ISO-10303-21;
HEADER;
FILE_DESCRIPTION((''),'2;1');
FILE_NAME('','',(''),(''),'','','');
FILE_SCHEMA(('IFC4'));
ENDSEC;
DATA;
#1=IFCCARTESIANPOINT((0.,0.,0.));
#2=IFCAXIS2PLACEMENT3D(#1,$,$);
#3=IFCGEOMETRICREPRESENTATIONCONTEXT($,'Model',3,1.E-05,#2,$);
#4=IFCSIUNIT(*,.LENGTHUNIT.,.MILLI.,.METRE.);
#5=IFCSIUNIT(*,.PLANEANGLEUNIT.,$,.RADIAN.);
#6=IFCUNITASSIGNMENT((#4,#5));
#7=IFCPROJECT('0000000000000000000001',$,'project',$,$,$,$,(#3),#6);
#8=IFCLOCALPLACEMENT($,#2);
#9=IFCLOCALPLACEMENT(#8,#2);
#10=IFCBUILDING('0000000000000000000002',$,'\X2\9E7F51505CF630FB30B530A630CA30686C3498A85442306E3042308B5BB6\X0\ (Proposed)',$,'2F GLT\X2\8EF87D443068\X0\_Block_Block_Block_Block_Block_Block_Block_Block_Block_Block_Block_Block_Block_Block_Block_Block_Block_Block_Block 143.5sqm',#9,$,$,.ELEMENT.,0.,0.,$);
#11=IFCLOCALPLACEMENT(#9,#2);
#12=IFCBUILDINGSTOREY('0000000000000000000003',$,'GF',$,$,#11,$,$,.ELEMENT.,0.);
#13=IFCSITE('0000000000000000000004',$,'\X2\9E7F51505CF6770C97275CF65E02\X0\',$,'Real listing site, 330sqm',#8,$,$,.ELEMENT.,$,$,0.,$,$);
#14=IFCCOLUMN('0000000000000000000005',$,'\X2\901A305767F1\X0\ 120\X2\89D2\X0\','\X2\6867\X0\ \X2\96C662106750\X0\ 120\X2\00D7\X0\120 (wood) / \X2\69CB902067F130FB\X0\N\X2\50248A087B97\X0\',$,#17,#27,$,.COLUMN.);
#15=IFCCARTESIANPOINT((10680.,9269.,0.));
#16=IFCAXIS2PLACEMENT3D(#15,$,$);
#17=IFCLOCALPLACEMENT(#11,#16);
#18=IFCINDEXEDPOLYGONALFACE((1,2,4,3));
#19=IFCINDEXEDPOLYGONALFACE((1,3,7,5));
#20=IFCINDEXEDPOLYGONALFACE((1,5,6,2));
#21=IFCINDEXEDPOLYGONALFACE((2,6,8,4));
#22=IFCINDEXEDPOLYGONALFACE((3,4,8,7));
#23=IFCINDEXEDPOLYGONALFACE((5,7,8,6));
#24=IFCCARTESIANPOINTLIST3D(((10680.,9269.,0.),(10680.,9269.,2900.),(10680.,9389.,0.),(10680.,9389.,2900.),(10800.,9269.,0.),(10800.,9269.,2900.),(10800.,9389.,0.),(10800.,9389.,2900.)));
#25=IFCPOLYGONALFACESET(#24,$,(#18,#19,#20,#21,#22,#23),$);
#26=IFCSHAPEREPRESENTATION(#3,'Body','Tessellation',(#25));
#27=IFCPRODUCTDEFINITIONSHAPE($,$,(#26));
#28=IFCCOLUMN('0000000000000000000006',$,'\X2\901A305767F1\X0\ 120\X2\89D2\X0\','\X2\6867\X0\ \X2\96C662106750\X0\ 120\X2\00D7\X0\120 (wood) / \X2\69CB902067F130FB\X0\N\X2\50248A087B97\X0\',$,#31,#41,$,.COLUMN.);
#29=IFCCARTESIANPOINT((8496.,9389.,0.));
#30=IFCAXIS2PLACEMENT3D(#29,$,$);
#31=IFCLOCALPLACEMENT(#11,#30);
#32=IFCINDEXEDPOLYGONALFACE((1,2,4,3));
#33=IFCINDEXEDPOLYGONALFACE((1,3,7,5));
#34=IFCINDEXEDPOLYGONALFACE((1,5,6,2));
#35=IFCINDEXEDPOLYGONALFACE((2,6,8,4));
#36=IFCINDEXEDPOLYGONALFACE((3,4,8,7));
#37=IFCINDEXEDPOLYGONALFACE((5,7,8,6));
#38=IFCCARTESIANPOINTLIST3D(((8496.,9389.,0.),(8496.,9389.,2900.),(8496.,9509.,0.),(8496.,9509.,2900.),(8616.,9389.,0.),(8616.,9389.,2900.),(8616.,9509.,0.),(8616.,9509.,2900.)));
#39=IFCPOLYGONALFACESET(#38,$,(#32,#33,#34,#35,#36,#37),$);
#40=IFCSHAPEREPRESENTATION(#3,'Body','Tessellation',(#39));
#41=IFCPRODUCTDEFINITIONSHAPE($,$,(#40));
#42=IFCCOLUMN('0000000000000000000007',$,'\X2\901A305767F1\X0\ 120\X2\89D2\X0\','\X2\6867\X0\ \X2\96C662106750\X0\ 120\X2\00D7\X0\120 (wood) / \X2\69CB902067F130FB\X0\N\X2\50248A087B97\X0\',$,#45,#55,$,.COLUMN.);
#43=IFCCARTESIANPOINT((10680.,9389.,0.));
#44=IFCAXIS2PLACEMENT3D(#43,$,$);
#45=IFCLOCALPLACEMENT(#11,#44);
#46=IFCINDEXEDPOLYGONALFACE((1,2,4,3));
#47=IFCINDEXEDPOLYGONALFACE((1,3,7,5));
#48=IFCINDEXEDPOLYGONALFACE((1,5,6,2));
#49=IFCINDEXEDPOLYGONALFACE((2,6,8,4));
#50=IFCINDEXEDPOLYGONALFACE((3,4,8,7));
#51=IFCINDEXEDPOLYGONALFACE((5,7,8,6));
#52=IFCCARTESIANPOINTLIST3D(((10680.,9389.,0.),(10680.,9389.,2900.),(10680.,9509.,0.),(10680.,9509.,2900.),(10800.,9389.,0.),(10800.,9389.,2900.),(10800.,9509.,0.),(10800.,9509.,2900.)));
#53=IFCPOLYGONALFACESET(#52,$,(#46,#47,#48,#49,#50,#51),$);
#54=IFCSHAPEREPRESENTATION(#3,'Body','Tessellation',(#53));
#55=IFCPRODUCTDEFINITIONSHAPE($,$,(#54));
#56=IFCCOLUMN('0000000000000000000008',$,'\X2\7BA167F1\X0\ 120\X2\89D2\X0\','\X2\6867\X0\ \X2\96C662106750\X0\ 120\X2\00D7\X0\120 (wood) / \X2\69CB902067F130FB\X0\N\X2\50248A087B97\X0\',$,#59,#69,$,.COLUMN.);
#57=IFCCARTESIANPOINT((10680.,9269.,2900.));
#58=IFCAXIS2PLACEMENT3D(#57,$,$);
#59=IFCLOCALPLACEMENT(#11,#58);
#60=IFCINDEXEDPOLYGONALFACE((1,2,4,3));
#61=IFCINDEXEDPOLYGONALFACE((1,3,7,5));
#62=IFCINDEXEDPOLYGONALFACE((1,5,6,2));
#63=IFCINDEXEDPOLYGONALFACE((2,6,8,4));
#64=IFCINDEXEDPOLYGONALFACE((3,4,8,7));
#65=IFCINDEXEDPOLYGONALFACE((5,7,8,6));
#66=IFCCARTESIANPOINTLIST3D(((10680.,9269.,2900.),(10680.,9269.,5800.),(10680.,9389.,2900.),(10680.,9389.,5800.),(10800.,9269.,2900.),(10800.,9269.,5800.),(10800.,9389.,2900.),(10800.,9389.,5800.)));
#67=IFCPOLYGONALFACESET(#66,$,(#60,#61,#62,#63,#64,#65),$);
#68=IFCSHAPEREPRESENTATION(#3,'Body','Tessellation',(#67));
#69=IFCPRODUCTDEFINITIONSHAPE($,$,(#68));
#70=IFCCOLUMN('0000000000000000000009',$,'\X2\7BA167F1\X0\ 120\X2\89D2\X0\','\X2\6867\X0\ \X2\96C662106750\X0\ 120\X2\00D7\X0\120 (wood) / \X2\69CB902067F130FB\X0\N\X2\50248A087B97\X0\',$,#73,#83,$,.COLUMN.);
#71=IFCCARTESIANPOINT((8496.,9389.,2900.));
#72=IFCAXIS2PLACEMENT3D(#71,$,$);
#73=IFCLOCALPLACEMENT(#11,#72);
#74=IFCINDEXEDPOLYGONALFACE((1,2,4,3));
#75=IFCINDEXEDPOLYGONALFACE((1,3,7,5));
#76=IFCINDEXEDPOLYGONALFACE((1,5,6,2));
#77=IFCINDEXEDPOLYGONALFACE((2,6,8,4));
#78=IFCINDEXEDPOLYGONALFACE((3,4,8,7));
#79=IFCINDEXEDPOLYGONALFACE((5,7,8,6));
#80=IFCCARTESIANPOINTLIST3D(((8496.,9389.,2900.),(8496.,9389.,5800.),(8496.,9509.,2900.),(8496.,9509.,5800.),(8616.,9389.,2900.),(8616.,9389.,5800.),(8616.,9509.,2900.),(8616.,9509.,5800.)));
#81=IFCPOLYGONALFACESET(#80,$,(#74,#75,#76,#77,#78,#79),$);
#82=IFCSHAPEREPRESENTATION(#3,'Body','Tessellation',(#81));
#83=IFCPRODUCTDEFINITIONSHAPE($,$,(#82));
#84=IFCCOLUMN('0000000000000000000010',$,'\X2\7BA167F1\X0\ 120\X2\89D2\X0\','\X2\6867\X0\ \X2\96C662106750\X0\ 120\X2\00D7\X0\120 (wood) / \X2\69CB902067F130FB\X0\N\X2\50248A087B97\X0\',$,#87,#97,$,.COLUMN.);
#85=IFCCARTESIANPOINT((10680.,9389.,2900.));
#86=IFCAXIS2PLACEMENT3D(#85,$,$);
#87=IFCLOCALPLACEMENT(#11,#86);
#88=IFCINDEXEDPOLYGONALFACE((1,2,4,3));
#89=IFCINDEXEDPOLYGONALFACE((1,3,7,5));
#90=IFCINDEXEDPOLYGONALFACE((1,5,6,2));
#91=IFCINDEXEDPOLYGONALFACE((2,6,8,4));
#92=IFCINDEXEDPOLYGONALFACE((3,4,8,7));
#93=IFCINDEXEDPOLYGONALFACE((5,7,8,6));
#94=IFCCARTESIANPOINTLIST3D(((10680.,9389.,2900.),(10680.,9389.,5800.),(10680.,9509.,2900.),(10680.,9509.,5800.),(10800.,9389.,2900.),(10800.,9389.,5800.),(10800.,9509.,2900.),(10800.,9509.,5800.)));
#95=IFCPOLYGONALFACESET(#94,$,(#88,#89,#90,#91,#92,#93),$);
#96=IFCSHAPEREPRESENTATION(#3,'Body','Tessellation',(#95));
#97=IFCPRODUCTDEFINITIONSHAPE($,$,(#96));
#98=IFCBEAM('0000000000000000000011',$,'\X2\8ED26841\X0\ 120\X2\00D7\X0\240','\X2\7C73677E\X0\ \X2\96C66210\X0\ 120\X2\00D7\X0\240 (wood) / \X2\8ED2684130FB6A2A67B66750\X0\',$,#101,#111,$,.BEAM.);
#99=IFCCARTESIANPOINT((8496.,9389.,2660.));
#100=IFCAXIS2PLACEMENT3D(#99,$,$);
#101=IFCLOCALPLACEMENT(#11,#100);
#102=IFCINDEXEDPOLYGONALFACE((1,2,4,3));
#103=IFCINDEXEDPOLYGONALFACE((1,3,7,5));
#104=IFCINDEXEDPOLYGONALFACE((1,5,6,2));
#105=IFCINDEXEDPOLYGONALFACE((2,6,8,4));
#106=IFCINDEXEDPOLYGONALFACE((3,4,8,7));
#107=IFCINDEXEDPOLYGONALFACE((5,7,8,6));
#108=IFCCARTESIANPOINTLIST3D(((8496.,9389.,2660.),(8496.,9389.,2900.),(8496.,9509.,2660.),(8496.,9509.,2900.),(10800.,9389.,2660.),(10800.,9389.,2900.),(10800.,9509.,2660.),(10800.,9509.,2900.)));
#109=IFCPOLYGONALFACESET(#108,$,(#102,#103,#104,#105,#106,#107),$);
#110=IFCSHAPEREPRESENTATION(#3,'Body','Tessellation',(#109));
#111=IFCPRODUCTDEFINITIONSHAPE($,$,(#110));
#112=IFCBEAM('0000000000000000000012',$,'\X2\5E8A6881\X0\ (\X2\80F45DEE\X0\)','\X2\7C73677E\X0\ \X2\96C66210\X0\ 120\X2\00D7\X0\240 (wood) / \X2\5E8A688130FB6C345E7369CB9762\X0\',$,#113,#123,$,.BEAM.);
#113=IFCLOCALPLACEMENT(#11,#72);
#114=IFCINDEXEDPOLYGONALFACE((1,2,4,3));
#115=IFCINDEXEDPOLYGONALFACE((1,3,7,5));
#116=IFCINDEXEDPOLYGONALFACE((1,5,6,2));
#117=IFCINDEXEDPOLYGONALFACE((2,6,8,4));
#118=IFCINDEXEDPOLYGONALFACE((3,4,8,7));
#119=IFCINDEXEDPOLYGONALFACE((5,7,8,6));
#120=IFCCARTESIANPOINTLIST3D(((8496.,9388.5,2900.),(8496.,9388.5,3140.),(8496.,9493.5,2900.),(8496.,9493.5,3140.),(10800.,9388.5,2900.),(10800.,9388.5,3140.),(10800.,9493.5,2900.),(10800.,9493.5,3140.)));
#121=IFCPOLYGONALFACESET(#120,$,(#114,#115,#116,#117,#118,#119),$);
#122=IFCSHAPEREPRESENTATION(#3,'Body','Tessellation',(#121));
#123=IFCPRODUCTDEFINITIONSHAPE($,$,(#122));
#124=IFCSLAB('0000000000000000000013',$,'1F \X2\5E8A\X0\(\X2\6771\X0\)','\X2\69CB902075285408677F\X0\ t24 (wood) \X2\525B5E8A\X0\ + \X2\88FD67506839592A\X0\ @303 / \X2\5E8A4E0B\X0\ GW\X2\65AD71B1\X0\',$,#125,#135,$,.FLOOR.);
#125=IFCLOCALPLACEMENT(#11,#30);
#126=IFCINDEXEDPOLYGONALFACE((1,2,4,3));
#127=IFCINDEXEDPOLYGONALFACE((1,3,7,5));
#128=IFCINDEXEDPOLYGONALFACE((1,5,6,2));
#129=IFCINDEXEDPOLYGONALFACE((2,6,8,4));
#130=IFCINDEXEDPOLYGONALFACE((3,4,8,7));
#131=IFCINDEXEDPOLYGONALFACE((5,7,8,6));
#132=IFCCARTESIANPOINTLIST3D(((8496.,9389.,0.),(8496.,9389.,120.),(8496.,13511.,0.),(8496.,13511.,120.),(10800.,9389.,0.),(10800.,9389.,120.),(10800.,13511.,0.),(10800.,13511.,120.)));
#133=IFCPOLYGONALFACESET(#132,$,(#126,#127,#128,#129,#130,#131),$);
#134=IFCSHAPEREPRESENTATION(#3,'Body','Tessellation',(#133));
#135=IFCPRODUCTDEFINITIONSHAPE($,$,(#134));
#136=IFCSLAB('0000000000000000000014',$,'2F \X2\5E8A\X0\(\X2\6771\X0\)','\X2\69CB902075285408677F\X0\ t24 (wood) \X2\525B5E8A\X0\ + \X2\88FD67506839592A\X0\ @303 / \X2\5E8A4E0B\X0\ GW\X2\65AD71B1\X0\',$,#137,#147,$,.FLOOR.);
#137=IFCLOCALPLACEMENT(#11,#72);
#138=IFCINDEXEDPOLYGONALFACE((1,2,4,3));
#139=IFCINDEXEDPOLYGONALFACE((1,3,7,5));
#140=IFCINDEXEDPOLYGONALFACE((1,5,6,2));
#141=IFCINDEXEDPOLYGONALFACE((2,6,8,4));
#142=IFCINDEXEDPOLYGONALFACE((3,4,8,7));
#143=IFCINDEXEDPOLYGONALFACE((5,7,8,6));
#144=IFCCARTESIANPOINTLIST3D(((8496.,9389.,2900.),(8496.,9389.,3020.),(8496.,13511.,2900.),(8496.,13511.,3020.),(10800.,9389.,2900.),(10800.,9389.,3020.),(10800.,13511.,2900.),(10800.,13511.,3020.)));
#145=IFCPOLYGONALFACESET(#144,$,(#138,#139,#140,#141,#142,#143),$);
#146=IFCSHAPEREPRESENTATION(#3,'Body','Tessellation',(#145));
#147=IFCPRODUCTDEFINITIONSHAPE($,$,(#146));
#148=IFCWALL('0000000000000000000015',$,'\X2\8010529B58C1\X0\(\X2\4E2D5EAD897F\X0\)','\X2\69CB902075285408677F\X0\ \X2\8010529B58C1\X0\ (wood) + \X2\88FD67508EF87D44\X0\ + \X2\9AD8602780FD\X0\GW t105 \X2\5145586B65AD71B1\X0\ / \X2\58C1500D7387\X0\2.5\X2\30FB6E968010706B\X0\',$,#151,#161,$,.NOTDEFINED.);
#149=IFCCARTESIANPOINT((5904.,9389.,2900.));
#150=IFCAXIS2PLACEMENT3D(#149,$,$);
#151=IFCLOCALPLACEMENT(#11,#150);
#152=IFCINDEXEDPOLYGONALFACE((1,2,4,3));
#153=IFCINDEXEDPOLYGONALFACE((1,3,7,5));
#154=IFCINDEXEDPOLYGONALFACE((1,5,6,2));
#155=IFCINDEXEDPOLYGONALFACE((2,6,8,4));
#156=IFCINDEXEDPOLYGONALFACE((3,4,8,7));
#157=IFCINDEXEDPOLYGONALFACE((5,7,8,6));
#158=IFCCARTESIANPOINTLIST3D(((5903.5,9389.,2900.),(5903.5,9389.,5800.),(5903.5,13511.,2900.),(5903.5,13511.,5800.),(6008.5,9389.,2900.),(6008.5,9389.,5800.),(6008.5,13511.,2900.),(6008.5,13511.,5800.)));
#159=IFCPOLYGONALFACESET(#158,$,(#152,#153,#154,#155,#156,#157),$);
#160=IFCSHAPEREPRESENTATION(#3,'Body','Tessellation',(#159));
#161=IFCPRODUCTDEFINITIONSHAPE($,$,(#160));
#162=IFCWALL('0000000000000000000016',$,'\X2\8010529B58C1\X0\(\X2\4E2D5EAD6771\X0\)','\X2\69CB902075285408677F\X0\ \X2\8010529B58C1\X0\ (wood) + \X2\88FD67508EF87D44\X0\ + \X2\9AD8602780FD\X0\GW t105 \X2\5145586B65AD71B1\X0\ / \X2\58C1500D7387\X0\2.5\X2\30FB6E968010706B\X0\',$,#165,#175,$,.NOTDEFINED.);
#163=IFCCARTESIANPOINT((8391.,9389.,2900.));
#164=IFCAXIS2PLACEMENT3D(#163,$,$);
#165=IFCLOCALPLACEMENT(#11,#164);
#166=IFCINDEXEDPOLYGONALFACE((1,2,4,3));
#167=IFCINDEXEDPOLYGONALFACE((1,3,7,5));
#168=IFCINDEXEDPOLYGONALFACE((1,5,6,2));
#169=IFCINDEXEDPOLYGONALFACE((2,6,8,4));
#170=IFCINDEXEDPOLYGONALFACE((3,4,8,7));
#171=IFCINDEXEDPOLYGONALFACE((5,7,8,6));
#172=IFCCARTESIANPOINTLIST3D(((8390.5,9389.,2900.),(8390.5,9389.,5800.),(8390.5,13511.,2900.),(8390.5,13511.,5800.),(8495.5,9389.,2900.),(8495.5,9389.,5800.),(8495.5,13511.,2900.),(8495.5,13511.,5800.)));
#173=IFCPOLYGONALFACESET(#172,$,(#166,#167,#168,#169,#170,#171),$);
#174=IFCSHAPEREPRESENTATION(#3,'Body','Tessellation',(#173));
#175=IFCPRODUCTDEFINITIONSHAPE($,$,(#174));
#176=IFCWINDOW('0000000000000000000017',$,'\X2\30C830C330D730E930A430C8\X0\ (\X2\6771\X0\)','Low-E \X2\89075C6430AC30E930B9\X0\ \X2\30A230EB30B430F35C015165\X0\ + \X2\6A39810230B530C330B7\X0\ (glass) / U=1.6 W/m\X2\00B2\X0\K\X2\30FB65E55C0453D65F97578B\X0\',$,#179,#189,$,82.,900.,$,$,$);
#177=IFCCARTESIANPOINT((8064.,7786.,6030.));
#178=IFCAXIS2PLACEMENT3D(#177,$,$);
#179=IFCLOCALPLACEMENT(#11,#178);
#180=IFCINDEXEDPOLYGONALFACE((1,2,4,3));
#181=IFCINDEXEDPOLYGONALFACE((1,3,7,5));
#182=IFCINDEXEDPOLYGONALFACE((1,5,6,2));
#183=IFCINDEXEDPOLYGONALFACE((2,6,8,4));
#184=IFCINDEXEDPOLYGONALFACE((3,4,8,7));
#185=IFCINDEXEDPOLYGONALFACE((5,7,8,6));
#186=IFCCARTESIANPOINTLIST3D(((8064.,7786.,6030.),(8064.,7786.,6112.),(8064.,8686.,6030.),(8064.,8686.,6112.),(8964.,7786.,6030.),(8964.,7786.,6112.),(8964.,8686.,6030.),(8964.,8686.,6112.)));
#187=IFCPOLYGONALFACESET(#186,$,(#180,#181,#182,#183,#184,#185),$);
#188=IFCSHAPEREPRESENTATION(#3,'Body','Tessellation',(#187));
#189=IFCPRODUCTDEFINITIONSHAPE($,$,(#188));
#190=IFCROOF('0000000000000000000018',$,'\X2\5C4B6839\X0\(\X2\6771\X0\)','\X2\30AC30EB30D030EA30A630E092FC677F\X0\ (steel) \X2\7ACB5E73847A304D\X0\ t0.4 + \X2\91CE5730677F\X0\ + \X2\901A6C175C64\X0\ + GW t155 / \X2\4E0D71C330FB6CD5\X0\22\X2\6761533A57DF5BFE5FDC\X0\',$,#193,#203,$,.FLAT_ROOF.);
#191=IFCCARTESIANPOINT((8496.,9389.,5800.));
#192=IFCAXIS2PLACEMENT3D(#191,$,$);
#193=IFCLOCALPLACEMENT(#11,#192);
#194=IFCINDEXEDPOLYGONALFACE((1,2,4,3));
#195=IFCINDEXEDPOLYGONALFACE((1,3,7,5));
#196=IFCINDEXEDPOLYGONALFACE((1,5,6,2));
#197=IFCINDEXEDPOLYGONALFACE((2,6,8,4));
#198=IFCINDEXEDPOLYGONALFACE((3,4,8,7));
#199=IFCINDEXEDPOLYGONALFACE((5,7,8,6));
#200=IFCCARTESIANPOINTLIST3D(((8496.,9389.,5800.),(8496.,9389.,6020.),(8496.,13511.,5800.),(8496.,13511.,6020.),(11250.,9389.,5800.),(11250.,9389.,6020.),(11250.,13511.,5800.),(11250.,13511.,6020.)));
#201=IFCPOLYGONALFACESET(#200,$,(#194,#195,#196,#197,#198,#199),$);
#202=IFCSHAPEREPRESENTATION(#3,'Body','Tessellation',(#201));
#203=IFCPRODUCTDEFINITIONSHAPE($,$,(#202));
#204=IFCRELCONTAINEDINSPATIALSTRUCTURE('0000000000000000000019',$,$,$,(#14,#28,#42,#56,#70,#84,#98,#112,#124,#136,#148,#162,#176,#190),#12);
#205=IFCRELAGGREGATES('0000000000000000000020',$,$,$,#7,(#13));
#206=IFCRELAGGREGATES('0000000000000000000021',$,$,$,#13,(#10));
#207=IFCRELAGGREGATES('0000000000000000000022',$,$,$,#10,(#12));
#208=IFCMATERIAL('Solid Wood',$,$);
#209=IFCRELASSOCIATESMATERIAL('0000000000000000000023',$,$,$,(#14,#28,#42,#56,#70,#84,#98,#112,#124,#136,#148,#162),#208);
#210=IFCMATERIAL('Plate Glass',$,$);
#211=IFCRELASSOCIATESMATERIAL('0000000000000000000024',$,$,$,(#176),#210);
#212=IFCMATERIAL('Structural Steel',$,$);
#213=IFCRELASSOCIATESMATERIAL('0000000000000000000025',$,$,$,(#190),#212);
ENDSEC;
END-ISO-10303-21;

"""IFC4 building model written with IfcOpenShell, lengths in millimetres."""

from ifc_helpers import new_model, si_unit, frame, frame_2d, origin, place, context, project, spatial, rectangle, extrude, material, element, save


model = new_model("IFC4")

# Units and contexts
model_context = context("Model", 3, precision=1e-05, world=origin())
ifc_project = project(units=[si_unit("LENGTHUNIT", "METRE", prefix="MILLI"), si_unit("PLANEANGLEUNIT", "RADIAN")], contexts=[model_context])

# Site, building, storey
site_placement = place(None, origin())
site = spatial("IfcSite", under=ifc_project, at=site_placement, Name="鹿児島県霧島市", ObjectType="Real listing site, 330sqm", CompositionType="ELEMENT", RefElevation=0.0)
building_placement = place(site_placement, origin())
building = spatial("IfcBuilding", under=site, at=building_placement, Name="鹿児島・サウナと水風呂のある家 (Proposed)", ObjectType="2F GLT軸組と_Block_Block_Block_Block_Block_Block_Block_Block_Block_Block_Block_Block_Block_Block_Block_Block_Block_Block_Block 143.5sqm", CompositionType="ELEMENT", ElevationOfRefHeight=0.0, ElevationOfTerrain=0.0)
storey_placement = place(building_placement, origin())
storey = spatial("IfcBuildingStorey", under=building, at=storey_placement, Name="GF", CompositionType="ELEMENT", Elevation=0.0)

# Columns
ifc_material_1 = material(Name="Solid Wood")
column_1_placement = place(storey_placement, frame((10680.0, 9269.0, 0.0)))
element("IfcColumn", 1, at=column_1_placement, inside=storey, material=ifc_material_1, Name="通し柱 120角", Description="桧 集成材 120×120 (wood) / 構造柱・N値計算", PredefinedType="COLUMN", context=model_context, shape_type="SweptSolid", body=[
    extrude(rectangle(XDim=120.0, YDim=120.0, at=frame_2d((60.0, 60.0))), frame((10680.0, 9269.0, 0.0)), (0.0, 0.0, 1.0), 2900.0),
])
column_2_placement = place(storey_placement, frame((8496.0, 9389.0, 0.0)))
element("IfcColumn", 2, at=column_2_placement, inside=storey, material=ifc_material_1, Name="通し柱 120角", Description="桧 集成材 120×120 (wood) / 構造柱・N値計算", PredefinedType="COLUMN", context=model_context, shape_type="SweptSolid", body=[
    extrude(rectangle(XDim=120.0, YDim=120.0, at=frame_2d((60.0, 60.0))), frame((8496.0, 9389.0, 0.0)), (0.0, 0.0, 1.0), 2900.0),
])
column_3_placement = place(storey_placement, frame((10680.0, 9389.0, 0.0)))
element("IfcColumn", 3, at=column_3_placement, inside=storey, material=ifc_material_1, Name="通し柱 120角", Description="桧 集成材 120×120 (wood) / 構造柱・N値計算", PredefinedType="COLUMN", context=model_context, shape_type="SweptSolid", body=[
    extrude(rectangle(XDim=120.0, YDim=120.0, at=frame_2d((60.0, 60.0))), frame((10680.0, 9389.0, 0.0)), (0.0, 0.0, 1.0), 2900.0),
])
column_4_placement = place(storey_placement, frame((10680.0, 9269.0, 2900.0)))
element("IfcColumn", 4, at=column_4_placement, inside=storey, material=ifc_material_1, Name="管柱 120角", Description="桧 集成材 120×120 (wood) / 構造柱・N値計算", PredefinedType="COLUMN", context=model_context, shape_type="SweptSolid", body=[
    extrude(rectangle(XDim=120.0, YDim=120.0, at=frame_2d((60.0, 60.0))), frame((10680.0, 9269.0, 2900.0)), (0.0, 0.0, 1.0), 2900.0),
])
column_5_placement = place(storey_placement, frame((8496.0, 9389.0, 2900.0)))
element("IfcColumn", 5, at=column_5_placement, inside=storey, material=ifc_material_1, Name="管柱 120角", Description="桧 集成材 120×120 (wood) / 構造柱・N値計算", PredefinedType="COLUMN", context=model_context, shape_type="SweptSolid", body=[
    extrude(rectangle(XDim=120.0, YDim=120.0, at=frame_2d((60.0, 60.0))), frame((8496.0, 9389.0, 2900.0)), (0.0, 0.0, 1.0), 2900.0),
])
column_6_placement = place(storey_placement, frame((10680.0, 9389.0, 2900.0)))
element("IfcColumn", 6, at=column_6_placement, inside=storey, material=ifc_material_1, Name="管柱 120角", Description="桧 集成材 120×120 (wood) / 構造柱・N値計算", PredefinedType="COLUMN", context=model_context, shape_type="SweptSolid", body=[
    extrude(rectangle(XDim=120.0, YDim=120.0, at=frame_2d((60.0, 60.0))), frame((10680.0, 9389.0, 2900.0)), (0.0, 0.0, 1.0), 2900.0),
])

# Beams
beam_1_placement = place(storey_placement, frame((8496.0, 9389.0, 2660.0)))
element("IfcBeam", 7, at=beam_1_placement, inside=storey, material=ifc_material_1, Name="軒桁 120×240", Description="米松 集成 120×240 (wood) / 軒桁・横架材", PredefinedType="BEAM", context=model_context, shape_type="SweptSolid", body=[
    extrude(rectangle(XDim=2304.0, YDim=120.0, at=frame_2d((1152.0, 60.0))), frame((8496.0, 9389.0, 2660.0)), (0.0, 0.0, 1.0), 240.0),
])
beam_2_placement = place(storey_placement, frame((8496.0, 9389.0, 2900.0)))
element("IfcBeam", 8, at=beam_2_placement, inside=storey, material=ifc_material_1, Name="床梁 (胴差)", Description="米松 集成 120×240 (wood) / 床梁・水平構面", PredefinedType="BEAM", context=model_context, shape_type="SweptSolid", body=[
    extrude(rectangle(XDim=2304.0, YDim=105.0, at=frame_2d((1152.0, 52.0))), frame((8496.0, 9389.0, 2900.0)), (0.0, 0.0, 1.0), 240.0),
])

# Slabs
slab_1_placement = place(storey_placement, frame((8496.0, 9389.0, 0.0)))
element("IfcSlab", 9, at=slab_1_placement, inside=storey, material=ifc_material_1, Name="1F 床(東)", Description="構造用合板 t24 (wood) 剛床 + 製材根太 @303 / 床下 GW断熱", PredefinedType="FLOOR", context=model_context, shape_type="SweptSolid", body=[
    extrude(rectangle(XDim=2304.0, YDim=4122.0, at=frame_2d((1152.0, 2061.0))), frame((8496.0, 9389.0, 0.0)), (0.0, 0.0, 1.0), 120.0),
])
slab_2_placement = place(storey_placement, frame((8496.0, 9389.0, 2900.0)))
element("IfcSlab", 10, at=slab_2_placement, inside=storey, material=ifc_material_1, Name="2F 床(東)", Description="構造用合板 t24 (wood) 剛床 + 製材根太 @303 / 床下 GW断熱", PredefinedType="FLOOR", context=model_context, shape_type="SweptSolid", body=[
    extrude(rectangle(XDim=2304.0, YDim=4122.0, at=frame_2d((1152.0, 2061.0))), frame((8496.0, 9389.0, 2900.0)), (0.0, 0.0, 1.0), 120.0),
])

# Walls
wall_1_placement = place(storey_placement, frame((5904.0, 9389.0, 2900.0)))
element("IfcWall", 11, at=wall_1_placement, inside=storey, material=ifc_material_1, Name="耐力壁(中庭西)", Description="構造用合板 耐力壁 (wood) + 製材軸組 + 高性能GW t105 充填断熱 / 壁倍率2.5・準耐火", PredefinedType="NOTDEFINED", context=model_context, shape_type="SweptSolid", body=[
    extrude(rectangle(XDim=105.0, YDim=4122.0, at=frame_2d((52.0, 2061.0))), frame((5904.0, 9389.0, 2900.0)), (0.0, 0.0, 1.0), 2900.0),
])
wall_2_placement = place(storey_placement, frame((8391.0, 9389.0, 2900.0)))
element("IfcWall", 12, at=wall_2_placement, inside=storey, material=ifc_material_1, Name="耐力壁(中庭東)", Description="構造用合板 耐力壁 (wood) + 製材軸組 + 高性能GW t105 充填断熱 / 壁倍率2.5・準耐火", PredefinedType="NOTDEFINED", context=model_context, shape_type="SweptSolid", body=[
    extrude(rectangle(XDim=105.0, YDim=4122.0, at=frame_2d((52.0, 2061.0))), frame((8391.0, 9389.0, 2900.0)), (0.0, 0.0, 1.0), 2900.0),
])

# Window
ifc_material_2 = material(Name="Plate Glass")
window_placement = place(storey_placement, frame((8064.0, 7786.0, 6030.0)))
element("IfcWindow", 13, at=window_placement, inside=storey, material=ifc_material_2, Name="トップライト (東)", Description="Low-E 複層ガラス アルゴン封入 + 樹脂サッシ (glass) / U=1.6 W/m²K・日射取得型", OverallHeight=82.0, OverallWidth=900.0, context=model_context, shape_type="SweptSolid", body=[
    extrude(rectangle(XDim=900.0, YDim=900.0, at=frame_2d((450.0, 450.0))), frame((8064.0, 7786.0, 6030.0)), (0.0, 0.0, 1.0), 82.0),
])

# Roof
ifc_material_3 = material(Name="Structural Steel")
for number, where, name in (
    (14, (8496.0, 9389.0, 5800.0), "屋根(東)"),
):
    element("IfcRoof", number, at=place(storey_placement, frame(where)), inside=storey, material=ifc_material_3, Name=name, Description="ガルバリウム鋼板 (steel) 立平葺き t0.4 + 野地板 + 通気層 + GW t155 / 不燃・法22条区域対応", PredefinedType="FLAT_ROOF", context=model_context, shape_type="SweptSolid", body=[
        extrude(rectangle(XDim=2754.0, YDim=4122.0, at=frame_2d((1377.0, 2061.0))), frame((8496.0, 9389.0, 5800.0)), (0.0, 0.0, 1.0), 220.0),
    ])

save(model, "model.ifc")
